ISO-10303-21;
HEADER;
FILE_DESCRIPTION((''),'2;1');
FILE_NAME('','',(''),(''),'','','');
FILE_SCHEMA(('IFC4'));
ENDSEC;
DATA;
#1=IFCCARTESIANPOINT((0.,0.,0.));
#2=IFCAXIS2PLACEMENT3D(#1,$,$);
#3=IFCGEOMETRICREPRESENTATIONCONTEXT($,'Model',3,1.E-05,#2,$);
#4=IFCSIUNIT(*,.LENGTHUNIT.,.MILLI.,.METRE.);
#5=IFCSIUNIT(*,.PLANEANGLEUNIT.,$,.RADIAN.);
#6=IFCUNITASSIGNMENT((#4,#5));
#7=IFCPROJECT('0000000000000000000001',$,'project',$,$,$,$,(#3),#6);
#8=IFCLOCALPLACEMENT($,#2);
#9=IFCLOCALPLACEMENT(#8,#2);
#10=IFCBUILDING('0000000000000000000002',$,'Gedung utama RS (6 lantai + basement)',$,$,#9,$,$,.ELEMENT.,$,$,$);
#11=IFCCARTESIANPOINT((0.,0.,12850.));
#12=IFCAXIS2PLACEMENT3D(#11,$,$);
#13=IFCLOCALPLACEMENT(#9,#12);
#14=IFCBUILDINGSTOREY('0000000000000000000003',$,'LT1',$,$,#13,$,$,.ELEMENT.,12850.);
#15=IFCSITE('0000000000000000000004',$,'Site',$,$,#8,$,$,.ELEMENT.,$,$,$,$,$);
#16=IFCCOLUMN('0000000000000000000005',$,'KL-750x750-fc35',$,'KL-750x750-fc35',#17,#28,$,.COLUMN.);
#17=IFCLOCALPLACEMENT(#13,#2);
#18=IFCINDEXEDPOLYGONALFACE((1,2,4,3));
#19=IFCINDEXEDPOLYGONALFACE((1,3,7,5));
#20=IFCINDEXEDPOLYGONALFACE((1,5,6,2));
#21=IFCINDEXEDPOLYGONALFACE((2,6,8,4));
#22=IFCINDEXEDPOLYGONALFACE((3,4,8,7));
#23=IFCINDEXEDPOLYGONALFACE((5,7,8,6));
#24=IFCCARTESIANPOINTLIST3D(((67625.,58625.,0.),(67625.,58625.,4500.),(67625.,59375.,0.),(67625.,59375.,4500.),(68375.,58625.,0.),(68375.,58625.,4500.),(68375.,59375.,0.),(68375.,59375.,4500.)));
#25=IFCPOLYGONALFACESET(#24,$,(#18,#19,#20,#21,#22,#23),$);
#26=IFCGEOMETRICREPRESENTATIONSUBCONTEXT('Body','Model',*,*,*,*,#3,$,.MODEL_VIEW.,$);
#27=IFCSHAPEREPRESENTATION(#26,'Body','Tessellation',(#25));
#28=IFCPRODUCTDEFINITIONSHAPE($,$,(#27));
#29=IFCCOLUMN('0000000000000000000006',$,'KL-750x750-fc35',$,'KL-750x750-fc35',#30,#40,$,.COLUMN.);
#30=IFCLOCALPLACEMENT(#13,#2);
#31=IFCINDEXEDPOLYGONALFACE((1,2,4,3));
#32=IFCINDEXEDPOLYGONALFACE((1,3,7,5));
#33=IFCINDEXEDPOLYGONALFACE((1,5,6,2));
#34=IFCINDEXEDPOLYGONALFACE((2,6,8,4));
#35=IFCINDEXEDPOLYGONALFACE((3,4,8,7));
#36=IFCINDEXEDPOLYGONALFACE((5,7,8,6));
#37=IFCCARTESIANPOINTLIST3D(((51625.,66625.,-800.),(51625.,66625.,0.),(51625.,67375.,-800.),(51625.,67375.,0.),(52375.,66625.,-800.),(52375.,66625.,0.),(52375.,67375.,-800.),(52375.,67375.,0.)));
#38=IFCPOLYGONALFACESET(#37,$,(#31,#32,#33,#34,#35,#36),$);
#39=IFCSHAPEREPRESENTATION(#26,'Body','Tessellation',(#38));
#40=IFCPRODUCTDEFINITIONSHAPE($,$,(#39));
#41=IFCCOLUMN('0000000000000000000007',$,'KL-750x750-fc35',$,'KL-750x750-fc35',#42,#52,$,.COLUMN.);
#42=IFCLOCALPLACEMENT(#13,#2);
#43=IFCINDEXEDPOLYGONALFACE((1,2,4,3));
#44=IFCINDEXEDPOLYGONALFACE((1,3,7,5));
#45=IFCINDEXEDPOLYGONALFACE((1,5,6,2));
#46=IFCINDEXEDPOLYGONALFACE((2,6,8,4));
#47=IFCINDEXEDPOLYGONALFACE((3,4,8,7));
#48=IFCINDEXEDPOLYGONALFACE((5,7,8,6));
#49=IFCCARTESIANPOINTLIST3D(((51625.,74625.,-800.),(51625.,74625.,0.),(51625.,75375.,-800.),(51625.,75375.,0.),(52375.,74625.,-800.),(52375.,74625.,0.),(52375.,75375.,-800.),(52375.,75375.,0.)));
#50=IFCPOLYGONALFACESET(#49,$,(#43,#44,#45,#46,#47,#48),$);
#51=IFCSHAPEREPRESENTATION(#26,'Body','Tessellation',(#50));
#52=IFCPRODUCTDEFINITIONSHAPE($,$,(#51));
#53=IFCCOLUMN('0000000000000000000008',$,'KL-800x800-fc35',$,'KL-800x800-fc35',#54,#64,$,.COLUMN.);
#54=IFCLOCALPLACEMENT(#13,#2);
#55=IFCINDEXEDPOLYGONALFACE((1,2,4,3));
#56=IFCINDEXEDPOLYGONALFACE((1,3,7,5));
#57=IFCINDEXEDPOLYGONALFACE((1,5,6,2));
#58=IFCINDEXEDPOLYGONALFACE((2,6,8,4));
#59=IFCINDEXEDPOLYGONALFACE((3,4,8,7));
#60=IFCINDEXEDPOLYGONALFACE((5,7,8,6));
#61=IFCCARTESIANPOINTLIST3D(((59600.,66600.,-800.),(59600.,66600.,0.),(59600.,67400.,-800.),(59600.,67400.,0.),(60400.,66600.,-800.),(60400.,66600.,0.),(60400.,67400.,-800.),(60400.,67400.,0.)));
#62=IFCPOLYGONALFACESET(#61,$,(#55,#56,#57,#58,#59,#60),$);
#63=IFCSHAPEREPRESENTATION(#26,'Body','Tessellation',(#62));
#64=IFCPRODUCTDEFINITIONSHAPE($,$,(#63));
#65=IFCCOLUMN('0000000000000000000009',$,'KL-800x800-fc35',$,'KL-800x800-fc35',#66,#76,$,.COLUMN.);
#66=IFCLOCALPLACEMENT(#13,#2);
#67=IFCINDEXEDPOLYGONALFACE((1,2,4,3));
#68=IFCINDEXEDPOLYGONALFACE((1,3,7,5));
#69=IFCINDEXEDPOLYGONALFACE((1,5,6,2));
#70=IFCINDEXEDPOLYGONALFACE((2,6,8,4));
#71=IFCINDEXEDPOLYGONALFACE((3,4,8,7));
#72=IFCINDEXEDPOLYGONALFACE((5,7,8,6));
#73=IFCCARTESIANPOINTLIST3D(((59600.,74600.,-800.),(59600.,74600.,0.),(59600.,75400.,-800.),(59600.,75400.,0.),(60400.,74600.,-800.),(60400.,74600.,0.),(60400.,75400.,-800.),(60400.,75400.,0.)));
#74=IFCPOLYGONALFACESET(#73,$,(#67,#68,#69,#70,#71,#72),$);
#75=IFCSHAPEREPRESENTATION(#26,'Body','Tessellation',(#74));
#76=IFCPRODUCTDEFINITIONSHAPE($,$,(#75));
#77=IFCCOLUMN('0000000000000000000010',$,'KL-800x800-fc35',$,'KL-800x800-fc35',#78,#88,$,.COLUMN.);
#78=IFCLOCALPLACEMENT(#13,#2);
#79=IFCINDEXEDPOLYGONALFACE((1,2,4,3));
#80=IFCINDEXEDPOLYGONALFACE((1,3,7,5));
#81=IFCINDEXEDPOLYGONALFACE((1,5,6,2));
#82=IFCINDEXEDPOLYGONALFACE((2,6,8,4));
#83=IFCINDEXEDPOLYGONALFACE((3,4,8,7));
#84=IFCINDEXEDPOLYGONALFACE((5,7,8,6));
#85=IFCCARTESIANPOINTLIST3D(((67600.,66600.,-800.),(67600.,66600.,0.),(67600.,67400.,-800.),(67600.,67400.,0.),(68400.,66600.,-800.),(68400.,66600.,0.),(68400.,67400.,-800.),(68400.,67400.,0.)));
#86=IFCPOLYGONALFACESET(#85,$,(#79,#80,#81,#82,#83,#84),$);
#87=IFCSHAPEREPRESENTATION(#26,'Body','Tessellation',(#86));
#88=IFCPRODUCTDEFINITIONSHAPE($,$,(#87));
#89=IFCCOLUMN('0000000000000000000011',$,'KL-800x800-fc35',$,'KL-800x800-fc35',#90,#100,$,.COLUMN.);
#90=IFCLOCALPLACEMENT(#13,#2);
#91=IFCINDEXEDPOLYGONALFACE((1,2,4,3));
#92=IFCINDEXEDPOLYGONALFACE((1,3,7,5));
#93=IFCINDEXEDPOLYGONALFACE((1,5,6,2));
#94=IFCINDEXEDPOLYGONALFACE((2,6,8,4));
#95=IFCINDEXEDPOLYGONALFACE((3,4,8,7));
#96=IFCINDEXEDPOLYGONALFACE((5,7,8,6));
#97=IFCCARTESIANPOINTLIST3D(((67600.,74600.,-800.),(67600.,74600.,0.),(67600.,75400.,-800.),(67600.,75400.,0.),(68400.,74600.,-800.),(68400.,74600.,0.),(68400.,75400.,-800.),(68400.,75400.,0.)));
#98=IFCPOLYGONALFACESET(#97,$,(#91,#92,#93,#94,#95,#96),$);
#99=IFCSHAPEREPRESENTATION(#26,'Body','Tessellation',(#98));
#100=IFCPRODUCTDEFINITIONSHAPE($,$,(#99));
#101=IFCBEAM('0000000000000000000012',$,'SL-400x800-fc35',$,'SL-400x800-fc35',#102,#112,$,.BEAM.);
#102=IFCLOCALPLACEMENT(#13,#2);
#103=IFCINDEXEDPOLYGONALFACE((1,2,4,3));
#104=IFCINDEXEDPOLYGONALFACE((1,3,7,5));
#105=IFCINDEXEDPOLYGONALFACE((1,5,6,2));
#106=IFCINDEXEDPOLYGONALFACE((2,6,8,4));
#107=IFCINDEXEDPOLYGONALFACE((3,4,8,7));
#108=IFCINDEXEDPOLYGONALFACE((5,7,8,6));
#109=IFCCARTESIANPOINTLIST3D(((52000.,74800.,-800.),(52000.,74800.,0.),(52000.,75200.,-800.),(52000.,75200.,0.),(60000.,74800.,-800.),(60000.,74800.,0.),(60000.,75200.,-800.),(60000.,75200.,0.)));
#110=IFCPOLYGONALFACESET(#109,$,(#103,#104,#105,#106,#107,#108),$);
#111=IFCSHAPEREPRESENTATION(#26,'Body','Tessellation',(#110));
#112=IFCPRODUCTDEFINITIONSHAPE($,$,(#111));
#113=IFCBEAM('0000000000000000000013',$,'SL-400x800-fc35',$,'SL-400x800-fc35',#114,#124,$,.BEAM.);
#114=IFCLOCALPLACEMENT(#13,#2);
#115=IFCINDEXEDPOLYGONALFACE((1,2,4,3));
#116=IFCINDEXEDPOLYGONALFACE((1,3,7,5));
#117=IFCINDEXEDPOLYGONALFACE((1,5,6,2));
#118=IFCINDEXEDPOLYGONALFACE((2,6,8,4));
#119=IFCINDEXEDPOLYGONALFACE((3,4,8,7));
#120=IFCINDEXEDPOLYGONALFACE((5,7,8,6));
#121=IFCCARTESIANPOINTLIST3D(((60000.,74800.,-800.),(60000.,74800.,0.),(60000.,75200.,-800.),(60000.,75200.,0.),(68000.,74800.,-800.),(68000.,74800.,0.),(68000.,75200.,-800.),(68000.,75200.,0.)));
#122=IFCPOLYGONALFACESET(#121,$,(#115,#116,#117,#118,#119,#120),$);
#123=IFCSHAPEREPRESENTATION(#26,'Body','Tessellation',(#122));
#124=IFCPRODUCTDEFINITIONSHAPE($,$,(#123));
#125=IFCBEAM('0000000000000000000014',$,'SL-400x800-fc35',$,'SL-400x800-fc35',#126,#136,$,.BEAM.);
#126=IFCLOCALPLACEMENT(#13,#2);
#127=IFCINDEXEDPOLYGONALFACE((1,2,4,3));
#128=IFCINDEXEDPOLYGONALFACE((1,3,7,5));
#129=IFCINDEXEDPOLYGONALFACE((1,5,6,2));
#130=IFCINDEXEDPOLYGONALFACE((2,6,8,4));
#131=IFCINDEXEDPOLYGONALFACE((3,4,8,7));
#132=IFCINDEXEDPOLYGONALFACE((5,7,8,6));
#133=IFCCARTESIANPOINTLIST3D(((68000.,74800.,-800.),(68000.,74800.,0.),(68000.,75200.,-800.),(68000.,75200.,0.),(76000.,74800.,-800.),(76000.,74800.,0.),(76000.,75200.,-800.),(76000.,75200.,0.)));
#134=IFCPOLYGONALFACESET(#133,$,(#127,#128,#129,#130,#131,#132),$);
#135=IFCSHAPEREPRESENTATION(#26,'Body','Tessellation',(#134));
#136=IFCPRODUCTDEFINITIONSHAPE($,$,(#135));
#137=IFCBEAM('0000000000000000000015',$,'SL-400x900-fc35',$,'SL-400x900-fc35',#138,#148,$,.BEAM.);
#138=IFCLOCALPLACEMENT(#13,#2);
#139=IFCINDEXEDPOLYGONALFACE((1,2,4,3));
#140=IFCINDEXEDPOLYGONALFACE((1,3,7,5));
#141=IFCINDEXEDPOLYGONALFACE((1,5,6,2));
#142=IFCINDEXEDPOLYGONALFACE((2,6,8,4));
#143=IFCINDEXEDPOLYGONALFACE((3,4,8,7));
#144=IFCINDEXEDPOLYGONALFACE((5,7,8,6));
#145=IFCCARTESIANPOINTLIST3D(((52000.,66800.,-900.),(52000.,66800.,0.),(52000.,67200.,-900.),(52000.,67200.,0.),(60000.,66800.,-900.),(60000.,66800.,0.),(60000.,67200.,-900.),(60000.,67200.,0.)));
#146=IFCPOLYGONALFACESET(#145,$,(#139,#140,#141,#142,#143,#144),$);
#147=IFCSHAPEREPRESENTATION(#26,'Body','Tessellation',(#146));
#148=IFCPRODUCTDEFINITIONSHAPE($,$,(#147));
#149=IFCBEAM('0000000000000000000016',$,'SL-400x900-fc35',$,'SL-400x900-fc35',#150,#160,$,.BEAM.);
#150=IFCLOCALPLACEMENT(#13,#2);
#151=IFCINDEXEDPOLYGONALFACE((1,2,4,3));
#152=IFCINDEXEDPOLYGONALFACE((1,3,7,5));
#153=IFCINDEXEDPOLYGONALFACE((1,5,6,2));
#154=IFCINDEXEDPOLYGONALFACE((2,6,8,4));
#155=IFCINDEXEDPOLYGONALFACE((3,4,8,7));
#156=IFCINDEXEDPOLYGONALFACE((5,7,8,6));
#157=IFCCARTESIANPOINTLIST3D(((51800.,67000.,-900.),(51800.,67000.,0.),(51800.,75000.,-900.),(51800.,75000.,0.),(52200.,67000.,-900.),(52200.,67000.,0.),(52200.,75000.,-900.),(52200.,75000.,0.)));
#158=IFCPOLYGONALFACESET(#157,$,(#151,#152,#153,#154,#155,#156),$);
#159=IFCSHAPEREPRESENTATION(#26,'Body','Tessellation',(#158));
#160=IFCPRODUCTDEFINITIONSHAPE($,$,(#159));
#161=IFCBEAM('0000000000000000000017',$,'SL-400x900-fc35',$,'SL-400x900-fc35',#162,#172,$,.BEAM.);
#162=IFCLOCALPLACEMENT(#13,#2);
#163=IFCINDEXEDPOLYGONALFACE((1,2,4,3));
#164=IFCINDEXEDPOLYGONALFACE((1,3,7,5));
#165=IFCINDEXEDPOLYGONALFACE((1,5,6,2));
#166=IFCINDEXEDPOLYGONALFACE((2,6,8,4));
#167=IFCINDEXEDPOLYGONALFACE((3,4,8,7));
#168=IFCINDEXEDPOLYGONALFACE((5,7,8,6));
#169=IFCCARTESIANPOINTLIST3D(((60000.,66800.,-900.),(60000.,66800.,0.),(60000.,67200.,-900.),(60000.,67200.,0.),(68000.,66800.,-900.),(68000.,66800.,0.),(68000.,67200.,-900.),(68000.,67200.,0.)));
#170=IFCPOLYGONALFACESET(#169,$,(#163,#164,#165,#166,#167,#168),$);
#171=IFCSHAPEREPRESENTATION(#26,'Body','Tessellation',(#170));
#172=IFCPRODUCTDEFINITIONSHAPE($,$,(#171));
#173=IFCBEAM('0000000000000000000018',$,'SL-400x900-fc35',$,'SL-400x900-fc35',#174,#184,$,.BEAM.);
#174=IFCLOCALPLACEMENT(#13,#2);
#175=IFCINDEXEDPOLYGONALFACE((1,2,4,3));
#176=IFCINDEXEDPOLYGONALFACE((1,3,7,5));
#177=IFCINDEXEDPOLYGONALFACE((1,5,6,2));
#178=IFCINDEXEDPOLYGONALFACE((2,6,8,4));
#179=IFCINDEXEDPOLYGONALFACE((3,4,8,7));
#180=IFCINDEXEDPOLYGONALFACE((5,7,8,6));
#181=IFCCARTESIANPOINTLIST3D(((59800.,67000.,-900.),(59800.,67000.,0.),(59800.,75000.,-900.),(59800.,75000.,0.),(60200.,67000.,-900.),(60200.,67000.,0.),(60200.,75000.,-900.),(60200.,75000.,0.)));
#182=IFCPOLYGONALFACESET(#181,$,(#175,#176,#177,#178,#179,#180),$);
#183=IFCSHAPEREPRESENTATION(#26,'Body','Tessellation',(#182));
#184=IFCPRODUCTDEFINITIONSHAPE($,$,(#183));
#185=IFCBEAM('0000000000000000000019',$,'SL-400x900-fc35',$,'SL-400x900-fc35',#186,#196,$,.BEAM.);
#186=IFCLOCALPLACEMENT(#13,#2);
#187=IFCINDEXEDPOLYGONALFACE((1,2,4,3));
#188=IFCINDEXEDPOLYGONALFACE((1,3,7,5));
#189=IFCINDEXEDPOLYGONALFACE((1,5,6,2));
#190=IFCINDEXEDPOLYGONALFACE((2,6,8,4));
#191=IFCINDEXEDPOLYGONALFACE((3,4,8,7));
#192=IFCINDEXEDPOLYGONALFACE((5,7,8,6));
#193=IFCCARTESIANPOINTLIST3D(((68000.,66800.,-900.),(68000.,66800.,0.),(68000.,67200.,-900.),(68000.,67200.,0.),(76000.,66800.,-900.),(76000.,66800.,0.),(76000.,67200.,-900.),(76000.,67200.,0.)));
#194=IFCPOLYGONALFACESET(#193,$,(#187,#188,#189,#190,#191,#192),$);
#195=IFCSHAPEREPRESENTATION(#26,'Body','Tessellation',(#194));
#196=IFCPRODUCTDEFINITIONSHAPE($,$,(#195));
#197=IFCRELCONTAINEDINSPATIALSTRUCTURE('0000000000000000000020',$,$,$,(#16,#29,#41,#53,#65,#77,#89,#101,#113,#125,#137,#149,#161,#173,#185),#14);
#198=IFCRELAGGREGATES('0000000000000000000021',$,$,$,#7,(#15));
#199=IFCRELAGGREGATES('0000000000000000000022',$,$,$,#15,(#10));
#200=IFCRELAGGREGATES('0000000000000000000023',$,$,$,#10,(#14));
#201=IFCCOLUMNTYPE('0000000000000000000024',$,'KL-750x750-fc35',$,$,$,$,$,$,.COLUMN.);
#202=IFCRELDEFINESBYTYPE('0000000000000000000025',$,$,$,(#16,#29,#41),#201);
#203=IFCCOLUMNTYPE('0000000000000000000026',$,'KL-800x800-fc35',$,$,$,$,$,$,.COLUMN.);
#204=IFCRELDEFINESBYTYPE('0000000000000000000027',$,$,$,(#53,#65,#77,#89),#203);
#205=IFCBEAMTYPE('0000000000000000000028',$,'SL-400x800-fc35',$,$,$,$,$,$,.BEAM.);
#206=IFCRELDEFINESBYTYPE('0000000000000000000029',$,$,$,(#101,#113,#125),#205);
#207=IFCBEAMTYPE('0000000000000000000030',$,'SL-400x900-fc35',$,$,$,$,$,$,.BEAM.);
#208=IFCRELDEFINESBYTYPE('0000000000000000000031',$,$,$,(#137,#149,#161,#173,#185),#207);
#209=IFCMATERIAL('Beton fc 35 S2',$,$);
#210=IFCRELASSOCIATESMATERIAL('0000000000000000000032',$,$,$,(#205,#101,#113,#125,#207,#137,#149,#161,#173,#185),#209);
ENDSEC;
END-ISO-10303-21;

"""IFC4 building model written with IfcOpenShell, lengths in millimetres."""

from ifc_helpers import new_model, si_unit, frame, origin, origin_2d, place, context, subcontext, project, spatial, rectangle, extrude, material, material_profile, profile_set, profile_usage, type_object, element, save


model = new_model("IFC4")

# Units and contexts
model_context = context("Model", 3, precision=1e-05, world=origin())
body_context = subcontext(model_context, "Body", "Model", "MODEL_VIEW")
ifc_project = project(units=[si_unit("LENGTHUNIT", "METRE", prefix="MILLI"), si_unit("PLANEANGLEUNIT", "RADIAN")], contexts=[model_context])

# Site, building, storey
site_placement = place(None, origin())
site = spatial("IfcSite", under=ifc_project, at=site_placement, Name="Site", CompositionType="ELEMENT")
building_placement = place(site_placement, origin())
building = spatial("IfcBuilding", under=site, at=building_placement, Name="Gedung utama RS (6 lantai + basement)", CompositionType="ELEMENT")
storey_placement = place(building_placement, frame((0.0, 0.0, 12850.0)))
storey = spatial("IfcBuildingStorey", under=building, at=storey_placement, Name="LT1", CompositionType="ELEMENT", Elevation=12850.0)

# Columns
ifc_material_profile_1 = material_profile(None, rectangle(XDim=750.0, YDim=750.0, at=origin_2d()), Name="KL-750x750-fc35")
ifc_profile_set_1 = profile_set([ifc_material_profile_1], Name="KL-750x750-fc35")
ifc_profile_usage_1 = profile_usage(ifc_profile_set_1, cardinal=5)
column_type_1 = type_object("IfcColumnType", Name="KL-750x750-fc35", PredefinedType="COLUMN", material=ifc_profile_set_1)
column_placement = place(storey_placement, frame((68000.0, 59000.0, 0.0), z_axis=(0.0, 0.0, 1.0), x_axis=(1.0, 0.0, 0.0)))
element("IfcColumn", 1, at=column_placement, inside=storey, type_object=column_type_1, material=ifc_profile_usage_1, Name="KL-750x750-fc35", ObjectType="KL-750x750-fc35", PredefinedType="COLUMN", context=body_context, shape_type="SweptSolid", body=[
    extrude(rectangle(XDim=750.0, YDim=750.0, at=origin_2d()), origin(), (0.0, 0.0, 1.0), 4500.0),
])
for number, where, z_axis, x_axis, name in (
    (2, (52000.0, 67000.0, -800.0), (0.0, 0.0, 1.0), (1.0, 0.0, 0.0), "KL-750x750-fc35"),
    (3, (52000.0, 75000.0, -800.0), (0.0, 0.0, 1.0), (1.0, 0.0, 0.0), "KL-750x750-fc35"),
):
    element("IfcColumn", number, at=place(storey_placement, frame(where, z_axis=z_axis, x_axis=x_axis)), inside=storey, type_object=column_type_1, material=ifc_profile_usage_1, Name=name, ObjectType="KL-750x750-fc35", PredefinedType="COLUMN", context=body_context, shape_type="SweptSolid", body=[
        extrude(rectangle(XDim=750.0, YDim=750.0, at=origin_2d()), origin(), (0.0, 0.0, 1.0), 800.0),
    ])
ifc_material_profile_2 = material_profile(None, rectangle(XDim=800.0, YDim=800.0, at=origin_2d()), Name="KL-800x800-fc35")
ifc_profile_set_2 = profile_set([ifc_material_profile_2], Name="KL-800x800-fc35")
ifc_profile_usage_2 = profile_usage(ifc_profile_set_2, cardinal=5)
column_type_2 = type_object("IfcColumnType", Name="KL-800x800-fc35", PredefinedType="COLUMN", material=ifc_profile_set_2)
for number, where, z_axis, x_axis, name in (
    (4, (60000.0, 67000.0, -800.0), (0.0, 0.0, 1.0), (1.0, 0.0, 0.0), "KL-800x800-fc35"),
    (5, (60000.0, 75000.0, -800.0), (0.0, 0.0, 1.0), (1.0, 0.0, 0.0), "KL-800x800-fc35"),
    (6, (68000.0, 67000.0, -800.0), (0.0, 0.0, 1.0), (1.0, 0.0, 0.0), "KL-800x800-fc35"),
    (7, (68000.0, 75000.0, -800.0), (0.0, 0.0, 1.0), (1.0, 0.0, 0.0), "KL-800x800-fc35"),
):
    element("IfcColumn", number, at=place(storey_placement, frame(where, z_axis=z_axis, x_axis=x_axis)), inside=storey, type_object=column_type_2, material=ifc_profile_usage_2, Name=name, ObjectType="KL-800x800-fc35", PredefinedType="COLUMN", context=body_context, shape_type="SweptSolid", body=[
        extrude(rectangle(XDim=800.0, YDim=800.0, at=origin_2d()), origin(), (0.0, 0.0, 1.0), 800.0),
    ])

# Beams
ifc_material = material(Name="Beton fc 35 S2")
ifc_material_profile_3 = material_profile(ifc_material, rectangle(XDim=400.0, YDim=800.0, at=origin_2d()), Name="SL-400x800-fc35")
ifc_profile_set_3 = profile_set([ifc_material_profile_3], Name="SL-400x800-fc35")
ifc_profile_usage_3 = profile_usage(ifc_profile_set_3, cardinal=8)
beam_type_1 = type_object("IfcBeamType", Name="SL-400x800-fc35", PredefinedType="BEAM", material=ifc_profile_set_3)
for number, where, name in (
    (8, (52000.0, 75000.0, -400.0), "SL-400x800-fc35"),
    (9, (60000.0, 75000.0, -400.0), "SL-400x800-fc35"),
    (10, (68000.0, 75000.0, -400.0), "SL-400x800-fc35"),
):
    element("IfcBeam", number, at=place(storey_placement, frame(where)), inside=storey, type_object=beam_type_1, material=ifc_profile_usage_3, Name=name, ObjectType="SL-400x800-fc35", PredefinedType="BEAM", context=body_context, shape_type="SweptSolid", body=[
        extrude(rectangle(XDim=400.0, YDim=800.0, at=origin_2d()), frame((0.0, 0.0, 0.0), z_axis=(1.0, 0.0, 0.0), x_axis=(0.0, 1.0, 0.0)), (0.0, 0.0, 1.0), 8000.0),
    ])
ifc_material_profile_4 = material_profile(ifc_material, rectangle(XDim=400.0, YDim=900.0, at=origin_2d()), Name="SL-400x900-fc35")
ifc_profile_set_4 = profile_set([ifc_material_profile_4], Name="SL-400x900-fc35")
ifc_profile_usage_4 = profile_usage(ifc_profile_set_4, cardinal=8)
beam_type_2 = type_object("IfcBeamType", Name="SL-400x900-fc35", PredefinedType="BEAM", material=ifc_profile_set_4)
beam_1_placement = place(storey_placement, frame((52000.0, 67000.0, -450.0)))
element("IfcBeam", 11, at=beam_1_placement, inside=storey, type_object=beam_type_2, material=ifc_profile_usage_4, Name="SL-400x900-fc35", ObjectType="SL-400x900-fc35", PredefinedType="BEAM", context=body_context, shape_type="SweptSolid", body=[
    extrude(rectangle(XDim=400.0, YDim=900.0, at=origin_2d()), frame((0.0, 0.0, 0.0), z_axis=(1.0, 0.0, 0.0), x_axis=(0.0, 1.0, 0.0)), (0.0, 0.0, 1.0), 8000.0),
])
beam_2_placement = place(storey_placement, frame((52000.0, 67000.0, -450.0)))
element("IfcBeam", 12, at=beam_2_placement, inside=storey, type_object=beam_type_2, material=ifc_profile_usage_4, Name="SL-400x900-fc35", ObjectType="SL-400x900-fc35", PredefinedType="BEAM", context=body_context, shape_type="SweptSolid", body=[
    extrude(rectangle(XDim=400.0, YDim=900.0, at=origin_2d()), frame((0.0, 0.0, 0.0), z_axis=(0.0, 1.0, 0.0), x_axis=(-1.0, 0.0, 0.0)), (0.0, 0.0, 1.0), 8000.0),
])
beam_3_placement = place(storey_placement, frame((60000.0, 67000.0, -450.0)))
element("IfcBeam", 13, at=beam_3_placement, inside=storey, type_object=beam_type_2, material=ifc_profile_usage_4, Name="SL-400x900-fc35", ObjectType="SL-400x900-fc35", PredefinedType="BEAM", context=body_context, shape_type="SweptSolid", body=[
    extrude(rectangle(XDim=400.0, YDim=900.0, at=origin_2d()), frame((0.0, 0.0, 0.0), z_axis=(1.0, 0.0, 0.0), x_axis=(0.0, 1.0, 0.0)), (0.0, 0.0, 1.0), 8000.0),
])
beam_4_placement = place(storey_placement, frame((60000.0, 67000.0, -450.0)))
element("IfcBeam", 14, at=beam_4_placement, inside=storey, type_object=beam_type_2, material=ifc_profile_usage_4, Name="SL-400x900-fc35", ObjectType="SL-400x900-fc35", PredefinedType="BEAM", context=body_context, shape_type="SweptSolid", body=[
    extrude(rectangle(XDim=400.0, YDim=900.0, at=origin_2d()), frame((0.0, 0.0, 0.0), z_axis=(0.0, 1.0, 0.0), x_axis=(-1.0, 0.0, 0.0)), (0.0, 0.0, 1.0), 8000.0),
])
beam_5_placement = place(storey_placement, frame((68000.0, 67000.0, -450.0)))
element("IfcBeam", 15, at=beam_5_placement, inside=storey, type_object=beam_type_2, material=ifc_profile_usage_4, Name="SL-400x900-fc35", ObjectType="SL-400x900-fc35", PredefinedType="BEAM", context=body_context, shape_type="SweptSolid", body=[
    extrude(rectangle(XDim=400.0, YDim=900.0, at=origin_2d()), frame((0.0, 0.0, 0.0), z_axis=(1.0, 0.0, 0.0), x_axis=(0.0, 1.0, 0.0)), (0.0, 0.0, 1.0), 8000.0),
])

save(model, "model.ifc")
